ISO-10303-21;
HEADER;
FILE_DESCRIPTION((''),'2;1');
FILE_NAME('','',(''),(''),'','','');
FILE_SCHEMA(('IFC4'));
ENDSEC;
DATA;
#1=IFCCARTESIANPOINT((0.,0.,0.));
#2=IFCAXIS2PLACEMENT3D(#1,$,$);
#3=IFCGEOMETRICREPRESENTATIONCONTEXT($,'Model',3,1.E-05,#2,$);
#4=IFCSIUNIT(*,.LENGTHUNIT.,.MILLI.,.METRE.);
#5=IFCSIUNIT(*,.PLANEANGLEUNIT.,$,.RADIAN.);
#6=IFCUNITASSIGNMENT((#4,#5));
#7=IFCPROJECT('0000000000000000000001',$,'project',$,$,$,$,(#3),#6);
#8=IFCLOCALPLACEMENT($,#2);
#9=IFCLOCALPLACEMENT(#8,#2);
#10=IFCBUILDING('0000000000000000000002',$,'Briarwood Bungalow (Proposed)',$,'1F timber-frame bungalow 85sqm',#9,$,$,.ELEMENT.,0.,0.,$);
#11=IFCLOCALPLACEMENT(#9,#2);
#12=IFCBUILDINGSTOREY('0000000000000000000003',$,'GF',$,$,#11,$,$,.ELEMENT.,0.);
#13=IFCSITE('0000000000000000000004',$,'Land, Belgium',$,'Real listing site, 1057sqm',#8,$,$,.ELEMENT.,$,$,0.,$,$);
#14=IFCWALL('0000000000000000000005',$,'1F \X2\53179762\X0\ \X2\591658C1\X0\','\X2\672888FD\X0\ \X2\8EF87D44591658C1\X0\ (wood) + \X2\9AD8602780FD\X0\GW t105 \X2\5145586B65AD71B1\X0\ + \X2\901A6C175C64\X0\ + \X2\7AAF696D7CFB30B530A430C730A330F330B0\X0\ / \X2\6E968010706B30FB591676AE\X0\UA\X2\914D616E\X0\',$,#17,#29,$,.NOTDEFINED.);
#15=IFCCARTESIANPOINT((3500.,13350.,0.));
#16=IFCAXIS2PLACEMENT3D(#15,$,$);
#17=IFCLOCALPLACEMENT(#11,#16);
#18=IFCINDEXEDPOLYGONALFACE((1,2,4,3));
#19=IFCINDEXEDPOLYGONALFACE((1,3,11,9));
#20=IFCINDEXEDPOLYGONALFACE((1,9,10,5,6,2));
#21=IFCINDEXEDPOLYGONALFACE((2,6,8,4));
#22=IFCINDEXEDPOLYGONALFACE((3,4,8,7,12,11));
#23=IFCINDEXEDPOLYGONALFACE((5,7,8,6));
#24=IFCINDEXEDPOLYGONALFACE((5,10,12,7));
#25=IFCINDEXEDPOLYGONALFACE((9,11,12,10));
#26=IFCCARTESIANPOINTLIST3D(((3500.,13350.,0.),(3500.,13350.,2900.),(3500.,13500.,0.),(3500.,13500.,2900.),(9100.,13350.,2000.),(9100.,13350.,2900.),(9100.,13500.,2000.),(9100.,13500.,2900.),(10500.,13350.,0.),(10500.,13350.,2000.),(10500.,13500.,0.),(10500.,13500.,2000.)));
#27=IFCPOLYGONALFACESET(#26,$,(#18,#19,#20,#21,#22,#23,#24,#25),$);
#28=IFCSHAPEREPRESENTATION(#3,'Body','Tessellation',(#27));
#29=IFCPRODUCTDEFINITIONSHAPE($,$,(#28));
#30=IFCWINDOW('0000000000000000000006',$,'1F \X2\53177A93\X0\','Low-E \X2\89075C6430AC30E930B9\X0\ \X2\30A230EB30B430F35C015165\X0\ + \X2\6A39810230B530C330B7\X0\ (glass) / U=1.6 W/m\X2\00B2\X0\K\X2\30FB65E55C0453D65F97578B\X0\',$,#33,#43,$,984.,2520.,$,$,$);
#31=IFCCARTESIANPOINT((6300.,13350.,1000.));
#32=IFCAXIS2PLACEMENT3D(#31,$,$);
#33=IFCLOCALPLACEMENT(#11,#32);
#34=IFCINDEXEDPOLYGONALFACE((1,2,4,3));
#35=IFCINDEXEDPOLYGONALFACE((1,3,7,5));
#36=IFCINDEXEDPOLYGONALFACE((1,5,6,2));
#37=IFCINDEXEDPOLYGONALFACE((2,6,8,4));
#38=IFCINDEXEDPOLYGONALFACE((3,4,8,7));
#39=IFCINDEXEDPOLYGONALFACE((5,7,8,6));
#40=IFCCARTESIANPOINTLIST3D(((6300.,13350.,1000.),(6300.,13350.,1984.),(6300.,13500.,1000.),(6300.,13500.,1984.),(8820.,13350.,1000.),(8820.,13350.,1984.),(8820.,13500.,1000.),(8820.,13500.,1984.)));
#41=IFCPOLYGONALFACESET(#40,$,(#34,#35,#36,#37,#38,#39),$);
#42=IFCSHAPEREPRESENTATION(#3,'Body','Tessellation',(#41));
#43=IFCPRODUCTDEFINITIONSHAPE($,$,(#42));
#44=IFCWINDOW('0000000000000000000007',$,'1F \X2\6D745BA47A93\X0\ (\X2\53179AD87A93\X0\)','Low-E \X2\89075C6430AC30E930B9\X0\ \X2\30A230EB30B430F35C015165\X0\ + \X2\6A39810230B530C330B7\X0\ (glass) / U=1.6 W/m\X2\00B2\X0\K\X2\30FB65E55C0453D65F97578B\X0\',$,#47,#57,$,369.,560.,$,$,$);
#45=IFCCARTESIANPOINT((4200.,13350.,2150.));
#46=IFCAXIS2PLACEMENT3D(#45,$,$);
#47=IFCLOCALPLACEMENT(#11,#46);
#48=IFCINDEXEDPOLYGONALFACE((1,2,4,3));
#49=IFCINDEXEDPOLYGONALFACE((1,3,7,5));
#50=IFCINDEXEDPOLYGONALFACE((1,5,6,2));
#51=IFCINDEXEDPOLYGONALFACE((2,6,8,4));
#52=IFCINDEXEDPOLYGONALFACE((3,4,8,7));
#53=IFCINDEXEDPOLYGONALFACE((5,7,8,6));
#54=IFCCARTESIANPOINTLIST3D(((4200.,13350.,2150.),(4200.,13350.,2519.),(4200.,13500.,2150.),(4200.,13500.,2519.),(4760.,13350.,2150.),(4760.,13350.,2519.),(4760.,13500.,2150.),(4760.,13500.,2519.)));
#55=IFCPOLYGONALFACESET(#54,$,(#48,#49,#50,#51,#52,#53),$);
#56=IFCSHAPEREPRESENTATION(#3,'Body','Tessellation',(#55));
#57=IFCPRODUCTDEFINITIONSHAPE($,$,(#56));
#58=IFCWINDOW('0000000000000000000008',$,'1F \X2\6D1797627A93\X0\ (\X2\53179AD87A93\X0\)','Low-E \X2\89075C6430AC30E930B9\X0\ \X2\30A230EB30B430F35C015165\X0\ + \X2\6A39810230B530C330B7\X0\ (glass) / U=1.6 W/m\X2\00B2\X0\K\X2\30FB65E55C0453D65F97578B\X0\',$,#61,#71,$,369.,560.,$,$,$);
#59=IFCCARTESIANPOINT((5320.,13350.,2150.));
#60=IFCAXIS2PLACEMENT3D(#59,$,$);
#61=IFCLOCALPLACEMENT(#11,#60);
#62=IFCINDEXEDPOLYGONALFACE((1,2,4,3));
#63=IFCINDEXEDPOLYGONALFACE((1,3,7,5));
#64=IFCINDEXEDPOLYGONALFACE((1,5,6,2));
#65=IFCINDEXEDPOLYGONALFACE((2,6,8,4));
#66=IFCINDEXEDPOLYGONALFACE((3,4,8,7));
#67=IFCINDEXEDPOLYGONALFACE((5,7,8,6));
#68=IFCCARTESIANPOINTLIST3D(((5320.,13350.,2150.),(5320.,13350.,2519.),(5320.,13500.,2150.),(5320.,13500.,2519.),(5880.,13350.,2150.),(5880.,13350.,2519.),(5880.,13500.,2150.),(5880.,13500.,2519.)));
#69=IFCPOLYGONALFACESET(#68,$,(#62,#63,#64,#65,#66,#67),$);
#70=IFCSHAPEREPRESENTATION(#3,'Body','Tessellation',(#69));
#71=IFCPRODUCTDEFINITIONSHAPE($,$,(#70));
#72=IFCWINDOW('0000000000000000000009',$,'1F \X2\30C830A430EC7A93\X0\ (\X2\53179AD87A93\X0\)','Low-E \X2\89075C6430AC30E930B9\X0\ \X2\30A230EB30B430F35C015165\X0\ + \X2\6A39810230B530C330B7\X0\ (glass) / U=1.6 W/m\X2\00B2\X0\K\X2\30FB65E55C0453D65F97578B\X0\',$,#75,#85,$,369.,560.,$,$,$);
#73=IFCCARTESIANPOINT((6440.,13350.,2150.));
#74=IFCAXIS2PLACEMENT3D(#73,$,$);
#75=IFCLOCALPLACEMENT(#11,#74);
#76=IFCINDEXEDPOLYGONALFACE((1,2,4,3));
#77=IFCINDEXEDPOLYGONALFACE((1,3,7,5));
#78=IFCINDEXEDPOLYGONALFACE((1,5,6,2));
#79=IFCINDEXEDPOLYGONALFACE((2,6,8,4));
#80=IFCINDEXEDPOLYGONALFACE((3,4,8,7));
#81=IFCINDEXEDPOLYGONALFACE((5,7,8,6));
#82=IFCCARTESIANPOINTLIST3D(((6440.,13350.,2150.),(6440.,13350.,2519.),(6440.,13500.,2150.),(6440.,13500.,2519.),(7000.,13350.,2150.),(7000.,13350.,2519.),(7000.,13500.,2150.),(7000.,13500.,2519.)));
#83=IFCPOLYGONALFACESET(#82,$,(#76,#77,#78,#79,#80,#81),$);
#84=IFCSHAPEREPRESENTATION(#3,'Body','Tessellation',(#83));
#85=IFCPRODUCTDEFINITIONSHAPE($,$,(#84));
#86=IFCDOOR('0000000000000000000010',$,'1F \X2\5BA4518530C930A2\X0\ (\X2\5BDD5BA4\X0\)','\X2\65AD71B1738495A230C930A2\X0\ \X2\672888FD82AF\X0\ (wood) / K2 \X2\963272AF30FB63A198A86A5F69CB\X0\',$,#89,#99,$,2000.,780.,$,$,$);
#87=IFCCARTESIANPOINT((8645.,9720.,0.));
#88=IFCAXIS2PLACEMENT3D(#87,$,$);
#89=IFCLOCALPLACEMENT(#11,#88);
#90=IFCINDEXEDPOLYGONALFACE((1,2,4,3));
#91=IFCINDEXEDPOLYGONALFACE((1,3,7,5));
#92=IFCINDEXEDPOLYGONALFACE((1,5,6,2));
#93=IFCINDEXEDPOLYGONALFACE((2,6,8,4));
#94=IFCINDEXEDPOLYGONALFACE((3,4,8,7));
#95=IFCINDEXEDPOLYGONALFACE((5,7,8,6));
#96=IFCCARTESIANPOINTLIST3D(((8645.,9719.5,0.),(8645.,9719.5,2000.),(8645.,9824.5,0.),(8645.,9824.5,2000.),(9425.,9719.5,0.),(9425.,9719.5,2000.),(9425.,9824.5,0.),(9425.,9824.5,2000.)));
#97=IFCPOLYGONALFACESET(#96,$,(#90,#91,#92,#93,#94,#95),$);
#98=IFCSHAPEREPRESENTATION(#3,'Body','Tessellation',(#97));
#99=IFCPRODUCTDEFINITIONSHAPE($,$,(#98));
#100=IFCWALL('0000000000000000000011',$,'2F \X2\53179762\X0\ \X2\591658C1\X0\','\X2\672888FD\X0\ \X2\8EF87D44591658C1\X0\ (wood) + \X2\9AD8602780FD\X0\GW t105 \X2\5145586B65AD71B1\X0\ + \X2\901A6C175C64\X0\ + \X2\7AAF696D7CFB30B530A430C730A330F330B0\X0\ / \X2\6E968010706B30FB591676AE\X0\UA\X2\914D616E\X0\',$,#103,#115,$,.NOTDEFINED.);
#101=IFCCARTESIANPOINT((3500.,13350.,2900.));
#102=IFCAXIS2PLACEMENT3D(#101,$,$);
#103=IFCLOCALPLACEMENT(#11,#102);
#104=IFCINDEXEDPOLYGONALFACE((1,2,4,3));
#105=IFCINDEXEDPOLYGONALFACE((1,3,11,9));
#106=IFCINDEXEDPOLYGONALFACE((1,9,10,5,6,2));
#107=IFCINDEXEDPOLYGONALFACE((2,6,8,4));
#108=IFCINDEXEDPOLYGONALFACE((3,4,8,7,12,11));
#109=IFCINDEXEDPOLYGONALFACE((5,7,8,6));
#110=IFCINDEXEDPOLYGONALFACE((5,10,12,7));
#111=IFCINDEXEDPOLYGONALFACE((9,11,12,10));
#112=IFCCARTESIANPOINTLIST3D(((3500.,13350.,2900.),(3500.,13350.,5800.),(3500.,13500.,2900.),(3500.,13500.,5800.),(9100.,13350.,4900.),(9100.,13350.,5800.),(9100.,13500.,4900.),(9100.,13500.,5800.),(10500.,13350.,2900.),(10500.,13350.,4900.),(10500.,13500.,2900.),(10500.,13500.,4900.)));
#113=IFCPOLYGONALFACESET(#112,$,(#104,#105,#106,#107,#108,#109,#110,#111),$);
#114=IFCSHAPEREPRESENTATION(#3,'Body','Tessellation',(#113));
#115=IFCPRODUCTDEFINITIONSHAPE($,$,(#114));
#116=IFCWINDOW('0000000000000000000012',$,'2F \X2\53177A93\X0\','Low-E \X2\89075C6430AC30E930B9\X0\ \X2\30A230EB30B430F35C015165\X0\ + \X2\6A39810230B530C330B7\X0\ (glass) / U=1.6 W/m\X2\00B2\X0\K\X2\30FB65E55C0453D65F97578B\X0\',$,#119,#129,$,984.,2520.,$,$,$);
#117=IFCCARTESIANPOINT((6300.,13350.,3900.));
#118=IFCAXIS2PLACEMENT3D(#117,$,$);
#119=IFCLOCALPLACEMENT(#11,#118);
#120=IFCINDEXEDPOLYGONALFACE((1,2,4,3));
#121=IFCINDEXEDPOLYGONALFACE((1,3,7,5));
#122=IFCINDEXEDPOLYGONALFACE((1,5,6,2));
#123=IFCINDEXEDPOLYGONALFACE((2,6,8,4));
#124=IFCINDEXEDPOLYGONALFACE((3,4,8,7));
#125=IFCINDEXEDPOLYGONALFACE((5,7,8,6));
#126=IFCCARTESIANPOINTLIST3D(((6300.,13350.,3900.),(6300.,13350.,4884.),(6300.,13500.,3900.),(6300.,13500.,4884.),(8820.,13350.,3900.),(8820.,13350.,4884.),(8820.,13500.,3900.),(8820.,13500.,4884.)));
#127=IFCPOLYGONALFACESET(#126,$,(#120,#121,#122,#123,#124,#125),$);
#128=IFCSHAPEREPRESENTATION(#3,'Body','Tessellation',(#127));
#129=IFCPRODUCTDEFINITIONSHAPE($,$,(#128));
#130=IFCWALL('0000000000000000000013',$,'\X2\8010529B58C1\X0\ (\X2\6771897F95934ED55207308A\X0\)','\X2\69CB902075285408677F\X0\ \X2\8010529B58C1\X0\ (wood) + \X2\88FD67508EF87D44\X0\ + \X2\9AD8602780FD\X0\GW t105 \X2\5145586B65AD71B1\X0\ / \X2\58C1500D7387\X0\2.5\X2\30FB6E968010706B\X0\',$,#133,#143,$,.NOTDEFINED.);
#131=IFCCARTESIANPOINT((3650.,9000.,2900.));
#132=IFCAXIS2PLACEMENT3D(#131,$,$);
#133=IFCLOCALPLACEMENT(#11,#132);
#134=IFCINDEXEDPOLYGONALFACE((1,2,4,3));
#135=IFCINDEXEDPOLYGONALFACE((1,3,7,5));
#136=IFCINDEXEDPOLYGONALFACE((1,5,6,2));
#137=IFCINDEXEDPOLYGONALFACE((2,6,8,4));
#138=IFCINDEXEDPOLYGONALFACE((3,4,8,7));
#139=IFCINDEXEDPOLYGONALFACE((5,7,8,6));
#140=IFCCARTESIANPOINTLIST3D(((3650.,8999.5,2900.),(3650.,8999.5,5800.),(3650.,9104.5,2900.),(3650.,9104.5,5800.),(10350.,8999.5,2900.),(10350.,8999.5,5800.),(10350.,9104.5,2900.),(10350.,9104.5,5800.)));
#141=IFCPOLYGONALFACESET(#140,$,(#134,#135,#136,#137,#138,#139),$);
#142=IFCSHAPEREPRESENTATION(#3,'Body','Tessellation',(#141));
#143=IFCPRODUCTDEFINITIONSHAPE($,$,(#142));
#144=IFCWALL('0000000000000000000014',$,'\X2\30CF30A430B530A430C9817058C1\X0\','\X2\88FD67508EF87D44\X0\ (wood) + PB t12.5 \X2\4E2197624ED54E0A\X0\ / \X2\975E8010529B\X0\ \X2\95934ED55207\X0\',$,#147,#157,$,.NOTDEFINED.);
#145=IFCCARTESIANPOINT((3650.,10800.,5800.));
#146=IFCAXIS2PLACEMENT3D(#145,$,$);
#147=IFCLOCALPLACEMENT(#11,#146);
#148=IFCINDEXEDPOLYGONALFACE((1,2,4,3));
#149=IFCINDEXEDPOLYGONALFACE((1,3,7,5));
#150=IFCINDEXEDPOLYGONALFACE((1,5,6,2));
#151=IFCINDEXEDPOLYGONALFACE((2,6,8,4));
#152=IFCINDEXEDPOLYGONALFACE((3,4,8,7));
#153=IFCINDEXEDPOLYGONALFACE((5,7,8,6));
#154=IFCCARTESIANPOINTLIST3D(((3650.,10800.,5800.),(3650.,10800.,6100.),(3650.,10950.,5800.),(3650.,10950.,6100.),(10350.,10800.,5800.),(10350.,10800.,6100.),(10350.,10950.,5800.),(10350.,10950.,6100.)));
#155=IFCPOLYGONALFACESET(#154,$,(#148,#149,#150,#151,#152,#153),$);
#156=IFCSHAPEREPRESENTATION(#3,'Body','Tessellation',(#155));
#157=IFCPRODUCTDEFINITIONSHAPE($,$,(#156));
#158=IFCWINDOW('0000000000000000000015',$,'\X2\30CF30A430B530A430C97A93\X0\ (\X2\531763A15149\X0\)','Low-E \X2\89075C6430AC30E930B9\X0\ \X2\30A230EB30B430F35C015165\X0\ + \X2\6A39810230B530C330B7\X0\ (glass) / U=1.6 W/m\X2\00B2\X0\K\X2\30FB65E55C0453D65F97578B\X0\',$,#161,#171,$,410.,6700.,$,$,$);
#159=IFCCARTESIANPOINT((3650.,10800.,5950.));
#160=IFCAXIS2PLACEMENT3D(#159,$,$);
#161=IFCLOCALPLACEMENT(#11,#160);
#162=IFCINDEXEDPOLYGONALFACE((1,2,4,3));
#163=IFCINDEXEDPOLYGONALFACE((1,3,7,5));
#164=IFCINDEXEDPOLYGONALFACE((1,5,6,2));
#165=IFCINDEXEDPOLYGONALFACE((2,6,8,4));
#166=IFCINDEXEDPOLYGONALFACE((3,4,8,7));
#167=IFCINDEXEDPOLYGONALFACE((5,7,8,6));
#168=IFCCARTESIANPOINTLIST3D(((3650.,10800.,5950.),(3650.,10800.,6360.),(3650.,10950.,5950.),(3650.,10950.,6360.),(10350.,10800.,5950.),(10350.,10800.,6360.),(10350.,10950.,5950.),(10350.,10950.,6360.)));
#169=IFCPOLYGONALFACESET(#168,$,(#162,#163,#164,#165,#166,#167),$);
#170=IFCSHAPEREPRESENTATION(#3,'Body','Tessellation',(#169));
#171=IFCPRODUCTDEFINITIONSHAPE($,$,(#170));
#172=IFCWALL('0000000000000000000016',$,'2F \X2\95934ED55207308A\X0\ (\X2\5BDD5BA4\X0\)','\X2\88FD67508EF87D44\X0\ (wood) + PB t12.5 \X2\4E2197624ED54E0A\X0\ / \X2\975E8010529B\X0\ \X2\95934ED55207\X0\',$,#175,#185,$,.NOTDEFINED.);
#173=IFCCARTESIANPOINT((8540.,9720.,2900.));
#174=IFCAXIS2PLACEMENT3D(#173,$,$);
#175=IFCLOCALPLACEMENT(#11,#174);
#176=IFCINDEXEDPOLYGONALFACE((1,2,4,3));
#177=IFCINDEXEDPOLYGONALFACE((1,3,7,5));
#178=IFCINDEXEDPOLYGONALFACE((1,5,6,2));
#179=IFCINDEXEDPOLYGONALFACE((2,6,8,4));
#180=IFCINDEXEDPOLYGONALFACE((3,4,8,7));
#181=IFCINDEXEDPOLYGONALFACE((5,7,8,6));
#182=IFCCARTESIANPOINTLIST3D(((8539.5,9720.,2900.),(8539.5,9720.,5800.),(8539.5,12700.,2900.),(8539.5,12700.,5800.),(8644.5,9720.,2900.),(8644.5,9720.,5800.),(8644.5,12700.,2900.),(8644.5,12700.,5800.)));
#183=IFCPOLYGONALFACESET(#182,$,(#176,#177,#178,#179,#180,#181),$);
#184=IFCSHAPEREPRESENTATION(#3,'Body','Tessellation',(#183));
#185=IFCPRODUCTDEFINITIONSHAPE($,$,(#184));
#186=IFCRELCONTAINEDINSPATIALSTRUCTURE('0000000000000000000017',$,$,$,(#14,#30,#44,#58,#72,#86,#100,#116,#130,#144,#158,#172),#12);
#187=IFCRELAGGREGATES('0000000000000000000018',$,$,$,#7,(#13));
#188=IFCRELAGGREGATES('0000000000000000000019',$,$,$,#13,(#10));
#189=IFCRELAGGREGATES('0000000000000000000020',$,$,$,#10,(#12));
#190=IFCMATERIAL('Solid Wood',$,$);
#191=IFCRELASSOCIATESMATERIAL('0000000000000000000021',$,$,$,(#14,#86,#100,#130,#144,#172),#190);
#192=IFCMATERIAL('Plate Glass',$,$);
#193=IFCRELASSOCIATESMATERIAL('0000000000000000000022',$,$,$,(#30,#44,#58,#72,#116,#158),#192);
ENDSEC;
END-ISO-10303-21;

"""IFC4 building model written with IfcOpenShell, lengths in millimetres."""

from ifc_helpers import new_model, si_unit, frame, frame_2d, origin, place, context, project, spatial, rectangle, extrude, material, element, fill, save


model = new_model("IFC4")

# Units and contexts
model_context = context("Model", 3, precision=1e-05, world=origin())
ifc_project = project(units=[si_unit("LENGTHUNIT", "METRE", prefix="MILLI"), si_unit("PLANEANGLEUNIT", "RADIAN")], contexts=[model_context])

# Site, building, storey
site_placement = place(None, origin())
site = spatial("IfcSite", under=ifc_project, at=site_placement, Name="Land, Belgium", ObjectType="Real listing site, 1057sqm", CompositionType="ELEMENT", RefElevation=0.0)
building_placement = place(site_placement, origin())
building = spatial("IfcBuilding", under=site, at=building_placement, Name="Briarwood Bungalow (Proposed)", ObjectType="1F timber-frame bungalow 85sqm", CompositionType="ELEMENT", ElevationOfRefHeight=0.0, ElevationOfTerrain=0.0)
storey_placement = place(building_placement, origin())
storey = spatial("IfcBuildingStorey", under=building, at=storey_placement, Name="GF", CompositionType="ELEMENT", Elevation=0.0)

# Wall, openings, windows
ifc_material_1 = material(Name="Solid Wood")
wall_1_placement = place(storey_placement, frame((3500.0, 13350.0, 0.0)))
wall_1 = element("IfcWall", 1, at=wall_1_placement, inside=storey, material=ifc_material_1, Name="1F 北面 外壁", Description="木製 軸組外壁 (wood) + 高性能GW t105 充填断熱 + 通気層 + 窯業系サイディング / 準耐火・外皮UA配慮", PredefinedType="NOTDEFINED", context=model_context, shape_type="SweptSolid", body=[
    extrude(rectangle(XDim=7000.0, YDim=150.0, at=frame_2d((3500.0, 75.0))), frame((3500.0, 13350.0, 0.0)), (0.0, 0.0, 1.0), 2900.0),
])
opening_1_placement = place(storey_placement, frame((6300.0, 13350.0, 1000.0)))
opening_1 = element("IfcOpeningElement", 2, at=opening_1_placement, cuts=wall_1, PredefinedType="NOTDEFINED", context=model_context, shape_type="SweptSolid", body=[
    extrude(rectangle(XDim=2520.0, YDim=150.0, at=frame_2d((1260.0, 75.0))), frame((6300.0, 13350.0, 1000.0)), (0.0, 0.0, 1.0), 984.0),
])
opening_2_placement = place(storey_placement, frame((4200.0, 13350.0, 2150.0)))
opening_2 = element("IfcOpeningElement", 3, at=opening_2_placement, cuts=wall_1, PredefinedType="NOTDEFINED", context=model_context, shape_type="SweptSolid", body=[
    extrude(rectangle(XDim=560.0, YDim=150.0, at=frame_2d((280.0, 75.0))), frame((4200.0, 13350.0, 2150.0)), (0.0, 0.0, 1.0), 369.0),
])
opening_3_placement = place(storey_placement, frame((5320.0, 13350.0, 2150.0)))
opening_3 = element("IfcOpeningElement", 4, at=opening_3_placement, cuts=wall_1, PredefinedType="NOTDEFINED", context=model_context, shape_type="SweptSolid", body=[
    extrude(rectangle(XDim=560.0, YDim=150.0, at=frame_2d((280.0, 75.0))), frame((5320.0, 13350.0, 2150.0)), (0.0, 0.0, 1.0), 369.0),
])
opening_4_placement = place(storey_placement, frame((6440.0, 13350.0, 2150.0)))
opening_4 = element("IfcOpeningElement", 5, at=opening_4_placement, cuts=wall_1, PredefinedType="NOTDEFINED", context=model_context, shape_type="SweptSolid", body=[
    extrude(rectangle(XDim=560.0, YDim=150.0, at=frame_2d((280.0, 75.0))), frame((6440.0, 13350.0, 2150.0)), (0.0, 0.0, 1.0), 369.0),
])
ifc_material_2 = material(Name="Plate Glass")
window_1_placement = place(storey_placement, frame((6300.0, 13350.0, 1000.0)))
window_1 = element("IfcWindow", 6, at=window_1_placement, inside=storey, material=ifc_material_2, Name="1F 北窓", Description="Low-E 複層ガラス アルゴン封入 + 樹脂サッシ (glass) / U=1.6 W/m²K・日射取得型", OverallHeight=984.0, OverallWidth=2520.0, context=model_context, shape_type="SweptSolid", body=[
    extrude(rectangle(XDim=2520.0, YDim=150.0, at=frame_2d((1260.0, 75.0))), frame((6300.0, 13350.0, 1000.0)), (0.0, 0.0, 1.0), 984.0),
])
fill(opening_1, window_1)
window_2_placement = place(storey_placement, frame((4200.0, 13350.0, 2150.0)))
window_2 = element("IfcWindow", 7, at=window_2_placement, inside=storey, material=ifc_material_2, Name="1F 浴室窓 (北高窓)", Description="Low-E 複層ガラス アルゴン封入 + 樹脂サッシ (glass) / U=1.6 W/m²K・日射取得型", OverallHeight=369.0, OverallWidth=560.0, context=model_context, shape_type="SweptSolid", body=[
    extrude(rectangle(XDim=560.0, YDim=150.0, at=frame_2d((280.0, 75.0))), frame((4200.0, 13350.0, 2150.0)), (0.0, 0.0, 1.0), 369.0),
])
fill(opening_2, window_2)
window_3_placement = place(storey_placement, frame((5320.0, 13350.0, 2150.0)))
window_3 = element("IfcWindow", 8, at=window_3_placement, inside=storey, material=ifc_material_2, Name="1F 洗面窓 (北高窓)", Description="Low-E 複層ガラス アルゴン封入 + 樹脂サッシ (glass) / U=1.6 W/m²K・日射取得型", OverallHeight=369.0, OverallWidth=560.0, context=model_context, shape_type="SweptSolid", body=[
    extrude(rectangle(XDim=560.0, YDim=150.0, at=frame_2d((280.0, 75.0))), frame((5320.0, 13350.0, 2150.0)), (0.0, 0.0, 1.0), 369.0),
])
fill(opening_3, window_3)
window_4_placement = place(storey_placement, frame((6440.0, 13350.0, 2150.0)))
window_4 = element("IfcWindow", 9, at=window_4_placement, inside=storey, material=ifc_material_2, Name="1F トイレ窓 (北高窓)", Description="Low-E 複層ガラス アルゴン封入 + 樹脂サッシ (glass) / U=1.6 W/m²K・日射取得型", OverallHeight=369.0, OverallWidth=560.0, context=model_context, shape_type="SweptSolid", body=[
    extrude(rectangle(XDim=560.0, YDim=150.0, at=frame_2d((280.0, 75.0))), frame((6440.0, 13350.0, 2150.0)), (0.0, 0.0, 1.0), 369.0),
])
fill(opening_4, window_4)

# Door
door_1_placement = place(storey_placement, frame((8645.0, 9720.0, 0.0)))
element("IfcDoor", 10, at=door_1_placement, inside=storey, material=ifc_material_1, Name="1F 室内ドア (寝室)", Description="断熱玄関ドア 木製芯 (wood) / K2 防犯・採風機構", OverallHeight=2000.0, OverallWidth=780.0, context=model_context, shape_type="SweptSolid", body=[
    extrude(rectangle(XDim=780.0, YDim=105.0, at=frame_2d((390.0, 52.0))), frame((8645.0, 9720.0, 0.0)), (0.0, 0.0, 1.0), 2000.0),
])

# Wall, opening, window
wall_2_placement = place(storey_placement, frame((3500.0, 13350.0, 2900.0)))
wall_2 = element("IfcWall", 11, at=wall_2_placement, inside=storey, material=ifc_material_1, Name="2F 北面 外壁", Description="木製 軸組外壁 (wood) + 高性能GW t105 充填断熱 + 通気層 + 窯業系サイディング / 準耐火・外皮UA配慮", PredefinedType="NOTDEFINED", context=model_context, shape_type="SweptSolid", body=[
    extrude(rectangle(XDim=7000.0, YDim=150.0, at=frame_2d((3500.0, 75.0))), frame((3500.0, 13350.0, 2900.0)), (0.0, 0.0, 1.0), 2900.0),
])
opening_5_placement = place(storey_placement, frame((6300.0, 13350.0, 3900.0)))
opening_5 = element("IfcOpeningElement", 12, at=opening_5_placement, cuts=wall_2, PredefinedType="NOTDEFINED", context=model_context, shape_type="SweptSolid", body=[
    extrude(rectangle(XDim=2520.0, YDim=150.0, at=frame_2d((1260.0, 75.0))), frame((6300.0, 13350.0, 3900.0)), (0.0, 0.0, 1.0), 984.0),
])
window_5_placement = place(storey_placement, frame((6300.0, 13350.0, 3900.0)))
window_5 = element("IfcWindow", 13, at=window_5_placement, inside=storey, material=ifc_material_2, Name="2F 北窓", Description="Low-E 複層ガラス アルゴン封入 + 樹脂サッシ (glass) / U=1.6 W/m²K・日射取得型", OverallHeight=984.0, OverallWidth=2520.0, context=model_context, shape_type="SweptSolid", body=[
    extrude(rectangle(XDim=2520.0, YDim=150.0, at=frame_2d((1260.0, 75.0))), frame((6300.0, 13350.0, 3900.0)), (0.0, 0.0, 1.0), 984.0),
])
fill(opening_5, window_5)

# Wall
wall_3_placement = place(storey_placement, frame((3650.0, 9000.0, 2900.0)))
element("IfcWall", 14, at=wall_3_placement, inside=storey, material=ifc_material_1, Name="耐力壁 (東西間仕切り)", Description="構造用合板 耐力壁 (wood) + 製材軸組 + 高性能GW t105 充填断熱 / 壁倍率2.5・準耐火", PredefinedType="NOTDEFINED", context=model_context, shape_type="SweptSolid", body=[
    extrude(rectangle(XDim=6700.0, YDim=105.0, at=frame_2d((3350.0, 52.0))), frame((3650.0, 9000.0, 2900.0)), (0.0, 0.0, 1.0), 2900.0),
])

# Wall, opening, window
wall_4_placement = place(storey_placement, frame((3650.0, 10800.0, 5800.0)))
wall_4 = element("IfcWall", 15, at=wall_4_placement, inside=storey, material=ifc_material_1, Name="ハイサイド腰壁", Description="製材軸組 (wood) + PB t12.5 両面仕上 / 非耐力 間仕切", PredefinedType="NOTDEFINED", context=model_context, shape_type="SweptSolid", body=[
    extrude(rectangle(XDim=6700.0, YDim=150.0, at=frame_2d((3350.0, 75.0))), frame((3650.0, 10800.0, 5800.0)), (0.0, 0.0, 1.0), 700.0),
])
opening_6_placement = place(storey_placement, frame((3650.0, 10800.0, 5950.0)))
opening_6 = element("IfcOpeningElement", 16, at=opening_6_placement, cuts=wall_4, PredefinedType="NOTDEFINED", context=model_context, shape_type="SweptSolid", body=[
    extrude(rectangle(XDim=6700.0, YDim=150.0, at=frame_2d((3350.0, 75.0))), frame((3650.0, 10800.0, 5950.0)), (0.0, 0.0, 1.0), 410.0),
])
window_6_placement = place(storey_placement, frame((3650.0, 10800.0, 5950.0)))
window_6 = element("IfcWindow", 17, at=window_6_placement, inside=storey, material=ifc_material_2, Name="ハイサイド窓 (北採光)", Description="Low-E 複層ガラス アルゴン封入 + 樹脂サッシ (glass) / U=1.6 W/m²K・日射取得型", OverallHeight=410.0, OverallWidth=6700.0, context=model_context, shape_type="SweptSolid", body=[
    extrude(rectangle(XDim=6700.0, YDim=150.0, at=frame_2d((3350.0, 75.0))), frame((3650.0, 10800.0, 5950.0)), (0.0, 0.0, 1.0), 410.0),
])
fill(opening_6, window_6)

# Wall
wall_5_placement = place(storey_placement, frame((8540.0, 9720.0, 2900.0)))
element("IfcWall", 18, at=wall_5_placement, inside=storey, material=ifc_material_1, Name="2F 間仕切り (寝室)", Description="製材軸組 (wood) + PB t12.5 両面仕上 / 非耐力 間仕切", PredefinedType="NOTDEFINED", context=model_context, shape_type="SweptSolid", body=[
    extrude(rectangle(XDim=105.0, YDim=2980.0, at=frame_2d((52.0, 1490.0))), frame((8540.0, 9720.0, 2900.0)), (0.0, 0.0, 1.0), 2900.0),
])

save(model, "model.ifc")
